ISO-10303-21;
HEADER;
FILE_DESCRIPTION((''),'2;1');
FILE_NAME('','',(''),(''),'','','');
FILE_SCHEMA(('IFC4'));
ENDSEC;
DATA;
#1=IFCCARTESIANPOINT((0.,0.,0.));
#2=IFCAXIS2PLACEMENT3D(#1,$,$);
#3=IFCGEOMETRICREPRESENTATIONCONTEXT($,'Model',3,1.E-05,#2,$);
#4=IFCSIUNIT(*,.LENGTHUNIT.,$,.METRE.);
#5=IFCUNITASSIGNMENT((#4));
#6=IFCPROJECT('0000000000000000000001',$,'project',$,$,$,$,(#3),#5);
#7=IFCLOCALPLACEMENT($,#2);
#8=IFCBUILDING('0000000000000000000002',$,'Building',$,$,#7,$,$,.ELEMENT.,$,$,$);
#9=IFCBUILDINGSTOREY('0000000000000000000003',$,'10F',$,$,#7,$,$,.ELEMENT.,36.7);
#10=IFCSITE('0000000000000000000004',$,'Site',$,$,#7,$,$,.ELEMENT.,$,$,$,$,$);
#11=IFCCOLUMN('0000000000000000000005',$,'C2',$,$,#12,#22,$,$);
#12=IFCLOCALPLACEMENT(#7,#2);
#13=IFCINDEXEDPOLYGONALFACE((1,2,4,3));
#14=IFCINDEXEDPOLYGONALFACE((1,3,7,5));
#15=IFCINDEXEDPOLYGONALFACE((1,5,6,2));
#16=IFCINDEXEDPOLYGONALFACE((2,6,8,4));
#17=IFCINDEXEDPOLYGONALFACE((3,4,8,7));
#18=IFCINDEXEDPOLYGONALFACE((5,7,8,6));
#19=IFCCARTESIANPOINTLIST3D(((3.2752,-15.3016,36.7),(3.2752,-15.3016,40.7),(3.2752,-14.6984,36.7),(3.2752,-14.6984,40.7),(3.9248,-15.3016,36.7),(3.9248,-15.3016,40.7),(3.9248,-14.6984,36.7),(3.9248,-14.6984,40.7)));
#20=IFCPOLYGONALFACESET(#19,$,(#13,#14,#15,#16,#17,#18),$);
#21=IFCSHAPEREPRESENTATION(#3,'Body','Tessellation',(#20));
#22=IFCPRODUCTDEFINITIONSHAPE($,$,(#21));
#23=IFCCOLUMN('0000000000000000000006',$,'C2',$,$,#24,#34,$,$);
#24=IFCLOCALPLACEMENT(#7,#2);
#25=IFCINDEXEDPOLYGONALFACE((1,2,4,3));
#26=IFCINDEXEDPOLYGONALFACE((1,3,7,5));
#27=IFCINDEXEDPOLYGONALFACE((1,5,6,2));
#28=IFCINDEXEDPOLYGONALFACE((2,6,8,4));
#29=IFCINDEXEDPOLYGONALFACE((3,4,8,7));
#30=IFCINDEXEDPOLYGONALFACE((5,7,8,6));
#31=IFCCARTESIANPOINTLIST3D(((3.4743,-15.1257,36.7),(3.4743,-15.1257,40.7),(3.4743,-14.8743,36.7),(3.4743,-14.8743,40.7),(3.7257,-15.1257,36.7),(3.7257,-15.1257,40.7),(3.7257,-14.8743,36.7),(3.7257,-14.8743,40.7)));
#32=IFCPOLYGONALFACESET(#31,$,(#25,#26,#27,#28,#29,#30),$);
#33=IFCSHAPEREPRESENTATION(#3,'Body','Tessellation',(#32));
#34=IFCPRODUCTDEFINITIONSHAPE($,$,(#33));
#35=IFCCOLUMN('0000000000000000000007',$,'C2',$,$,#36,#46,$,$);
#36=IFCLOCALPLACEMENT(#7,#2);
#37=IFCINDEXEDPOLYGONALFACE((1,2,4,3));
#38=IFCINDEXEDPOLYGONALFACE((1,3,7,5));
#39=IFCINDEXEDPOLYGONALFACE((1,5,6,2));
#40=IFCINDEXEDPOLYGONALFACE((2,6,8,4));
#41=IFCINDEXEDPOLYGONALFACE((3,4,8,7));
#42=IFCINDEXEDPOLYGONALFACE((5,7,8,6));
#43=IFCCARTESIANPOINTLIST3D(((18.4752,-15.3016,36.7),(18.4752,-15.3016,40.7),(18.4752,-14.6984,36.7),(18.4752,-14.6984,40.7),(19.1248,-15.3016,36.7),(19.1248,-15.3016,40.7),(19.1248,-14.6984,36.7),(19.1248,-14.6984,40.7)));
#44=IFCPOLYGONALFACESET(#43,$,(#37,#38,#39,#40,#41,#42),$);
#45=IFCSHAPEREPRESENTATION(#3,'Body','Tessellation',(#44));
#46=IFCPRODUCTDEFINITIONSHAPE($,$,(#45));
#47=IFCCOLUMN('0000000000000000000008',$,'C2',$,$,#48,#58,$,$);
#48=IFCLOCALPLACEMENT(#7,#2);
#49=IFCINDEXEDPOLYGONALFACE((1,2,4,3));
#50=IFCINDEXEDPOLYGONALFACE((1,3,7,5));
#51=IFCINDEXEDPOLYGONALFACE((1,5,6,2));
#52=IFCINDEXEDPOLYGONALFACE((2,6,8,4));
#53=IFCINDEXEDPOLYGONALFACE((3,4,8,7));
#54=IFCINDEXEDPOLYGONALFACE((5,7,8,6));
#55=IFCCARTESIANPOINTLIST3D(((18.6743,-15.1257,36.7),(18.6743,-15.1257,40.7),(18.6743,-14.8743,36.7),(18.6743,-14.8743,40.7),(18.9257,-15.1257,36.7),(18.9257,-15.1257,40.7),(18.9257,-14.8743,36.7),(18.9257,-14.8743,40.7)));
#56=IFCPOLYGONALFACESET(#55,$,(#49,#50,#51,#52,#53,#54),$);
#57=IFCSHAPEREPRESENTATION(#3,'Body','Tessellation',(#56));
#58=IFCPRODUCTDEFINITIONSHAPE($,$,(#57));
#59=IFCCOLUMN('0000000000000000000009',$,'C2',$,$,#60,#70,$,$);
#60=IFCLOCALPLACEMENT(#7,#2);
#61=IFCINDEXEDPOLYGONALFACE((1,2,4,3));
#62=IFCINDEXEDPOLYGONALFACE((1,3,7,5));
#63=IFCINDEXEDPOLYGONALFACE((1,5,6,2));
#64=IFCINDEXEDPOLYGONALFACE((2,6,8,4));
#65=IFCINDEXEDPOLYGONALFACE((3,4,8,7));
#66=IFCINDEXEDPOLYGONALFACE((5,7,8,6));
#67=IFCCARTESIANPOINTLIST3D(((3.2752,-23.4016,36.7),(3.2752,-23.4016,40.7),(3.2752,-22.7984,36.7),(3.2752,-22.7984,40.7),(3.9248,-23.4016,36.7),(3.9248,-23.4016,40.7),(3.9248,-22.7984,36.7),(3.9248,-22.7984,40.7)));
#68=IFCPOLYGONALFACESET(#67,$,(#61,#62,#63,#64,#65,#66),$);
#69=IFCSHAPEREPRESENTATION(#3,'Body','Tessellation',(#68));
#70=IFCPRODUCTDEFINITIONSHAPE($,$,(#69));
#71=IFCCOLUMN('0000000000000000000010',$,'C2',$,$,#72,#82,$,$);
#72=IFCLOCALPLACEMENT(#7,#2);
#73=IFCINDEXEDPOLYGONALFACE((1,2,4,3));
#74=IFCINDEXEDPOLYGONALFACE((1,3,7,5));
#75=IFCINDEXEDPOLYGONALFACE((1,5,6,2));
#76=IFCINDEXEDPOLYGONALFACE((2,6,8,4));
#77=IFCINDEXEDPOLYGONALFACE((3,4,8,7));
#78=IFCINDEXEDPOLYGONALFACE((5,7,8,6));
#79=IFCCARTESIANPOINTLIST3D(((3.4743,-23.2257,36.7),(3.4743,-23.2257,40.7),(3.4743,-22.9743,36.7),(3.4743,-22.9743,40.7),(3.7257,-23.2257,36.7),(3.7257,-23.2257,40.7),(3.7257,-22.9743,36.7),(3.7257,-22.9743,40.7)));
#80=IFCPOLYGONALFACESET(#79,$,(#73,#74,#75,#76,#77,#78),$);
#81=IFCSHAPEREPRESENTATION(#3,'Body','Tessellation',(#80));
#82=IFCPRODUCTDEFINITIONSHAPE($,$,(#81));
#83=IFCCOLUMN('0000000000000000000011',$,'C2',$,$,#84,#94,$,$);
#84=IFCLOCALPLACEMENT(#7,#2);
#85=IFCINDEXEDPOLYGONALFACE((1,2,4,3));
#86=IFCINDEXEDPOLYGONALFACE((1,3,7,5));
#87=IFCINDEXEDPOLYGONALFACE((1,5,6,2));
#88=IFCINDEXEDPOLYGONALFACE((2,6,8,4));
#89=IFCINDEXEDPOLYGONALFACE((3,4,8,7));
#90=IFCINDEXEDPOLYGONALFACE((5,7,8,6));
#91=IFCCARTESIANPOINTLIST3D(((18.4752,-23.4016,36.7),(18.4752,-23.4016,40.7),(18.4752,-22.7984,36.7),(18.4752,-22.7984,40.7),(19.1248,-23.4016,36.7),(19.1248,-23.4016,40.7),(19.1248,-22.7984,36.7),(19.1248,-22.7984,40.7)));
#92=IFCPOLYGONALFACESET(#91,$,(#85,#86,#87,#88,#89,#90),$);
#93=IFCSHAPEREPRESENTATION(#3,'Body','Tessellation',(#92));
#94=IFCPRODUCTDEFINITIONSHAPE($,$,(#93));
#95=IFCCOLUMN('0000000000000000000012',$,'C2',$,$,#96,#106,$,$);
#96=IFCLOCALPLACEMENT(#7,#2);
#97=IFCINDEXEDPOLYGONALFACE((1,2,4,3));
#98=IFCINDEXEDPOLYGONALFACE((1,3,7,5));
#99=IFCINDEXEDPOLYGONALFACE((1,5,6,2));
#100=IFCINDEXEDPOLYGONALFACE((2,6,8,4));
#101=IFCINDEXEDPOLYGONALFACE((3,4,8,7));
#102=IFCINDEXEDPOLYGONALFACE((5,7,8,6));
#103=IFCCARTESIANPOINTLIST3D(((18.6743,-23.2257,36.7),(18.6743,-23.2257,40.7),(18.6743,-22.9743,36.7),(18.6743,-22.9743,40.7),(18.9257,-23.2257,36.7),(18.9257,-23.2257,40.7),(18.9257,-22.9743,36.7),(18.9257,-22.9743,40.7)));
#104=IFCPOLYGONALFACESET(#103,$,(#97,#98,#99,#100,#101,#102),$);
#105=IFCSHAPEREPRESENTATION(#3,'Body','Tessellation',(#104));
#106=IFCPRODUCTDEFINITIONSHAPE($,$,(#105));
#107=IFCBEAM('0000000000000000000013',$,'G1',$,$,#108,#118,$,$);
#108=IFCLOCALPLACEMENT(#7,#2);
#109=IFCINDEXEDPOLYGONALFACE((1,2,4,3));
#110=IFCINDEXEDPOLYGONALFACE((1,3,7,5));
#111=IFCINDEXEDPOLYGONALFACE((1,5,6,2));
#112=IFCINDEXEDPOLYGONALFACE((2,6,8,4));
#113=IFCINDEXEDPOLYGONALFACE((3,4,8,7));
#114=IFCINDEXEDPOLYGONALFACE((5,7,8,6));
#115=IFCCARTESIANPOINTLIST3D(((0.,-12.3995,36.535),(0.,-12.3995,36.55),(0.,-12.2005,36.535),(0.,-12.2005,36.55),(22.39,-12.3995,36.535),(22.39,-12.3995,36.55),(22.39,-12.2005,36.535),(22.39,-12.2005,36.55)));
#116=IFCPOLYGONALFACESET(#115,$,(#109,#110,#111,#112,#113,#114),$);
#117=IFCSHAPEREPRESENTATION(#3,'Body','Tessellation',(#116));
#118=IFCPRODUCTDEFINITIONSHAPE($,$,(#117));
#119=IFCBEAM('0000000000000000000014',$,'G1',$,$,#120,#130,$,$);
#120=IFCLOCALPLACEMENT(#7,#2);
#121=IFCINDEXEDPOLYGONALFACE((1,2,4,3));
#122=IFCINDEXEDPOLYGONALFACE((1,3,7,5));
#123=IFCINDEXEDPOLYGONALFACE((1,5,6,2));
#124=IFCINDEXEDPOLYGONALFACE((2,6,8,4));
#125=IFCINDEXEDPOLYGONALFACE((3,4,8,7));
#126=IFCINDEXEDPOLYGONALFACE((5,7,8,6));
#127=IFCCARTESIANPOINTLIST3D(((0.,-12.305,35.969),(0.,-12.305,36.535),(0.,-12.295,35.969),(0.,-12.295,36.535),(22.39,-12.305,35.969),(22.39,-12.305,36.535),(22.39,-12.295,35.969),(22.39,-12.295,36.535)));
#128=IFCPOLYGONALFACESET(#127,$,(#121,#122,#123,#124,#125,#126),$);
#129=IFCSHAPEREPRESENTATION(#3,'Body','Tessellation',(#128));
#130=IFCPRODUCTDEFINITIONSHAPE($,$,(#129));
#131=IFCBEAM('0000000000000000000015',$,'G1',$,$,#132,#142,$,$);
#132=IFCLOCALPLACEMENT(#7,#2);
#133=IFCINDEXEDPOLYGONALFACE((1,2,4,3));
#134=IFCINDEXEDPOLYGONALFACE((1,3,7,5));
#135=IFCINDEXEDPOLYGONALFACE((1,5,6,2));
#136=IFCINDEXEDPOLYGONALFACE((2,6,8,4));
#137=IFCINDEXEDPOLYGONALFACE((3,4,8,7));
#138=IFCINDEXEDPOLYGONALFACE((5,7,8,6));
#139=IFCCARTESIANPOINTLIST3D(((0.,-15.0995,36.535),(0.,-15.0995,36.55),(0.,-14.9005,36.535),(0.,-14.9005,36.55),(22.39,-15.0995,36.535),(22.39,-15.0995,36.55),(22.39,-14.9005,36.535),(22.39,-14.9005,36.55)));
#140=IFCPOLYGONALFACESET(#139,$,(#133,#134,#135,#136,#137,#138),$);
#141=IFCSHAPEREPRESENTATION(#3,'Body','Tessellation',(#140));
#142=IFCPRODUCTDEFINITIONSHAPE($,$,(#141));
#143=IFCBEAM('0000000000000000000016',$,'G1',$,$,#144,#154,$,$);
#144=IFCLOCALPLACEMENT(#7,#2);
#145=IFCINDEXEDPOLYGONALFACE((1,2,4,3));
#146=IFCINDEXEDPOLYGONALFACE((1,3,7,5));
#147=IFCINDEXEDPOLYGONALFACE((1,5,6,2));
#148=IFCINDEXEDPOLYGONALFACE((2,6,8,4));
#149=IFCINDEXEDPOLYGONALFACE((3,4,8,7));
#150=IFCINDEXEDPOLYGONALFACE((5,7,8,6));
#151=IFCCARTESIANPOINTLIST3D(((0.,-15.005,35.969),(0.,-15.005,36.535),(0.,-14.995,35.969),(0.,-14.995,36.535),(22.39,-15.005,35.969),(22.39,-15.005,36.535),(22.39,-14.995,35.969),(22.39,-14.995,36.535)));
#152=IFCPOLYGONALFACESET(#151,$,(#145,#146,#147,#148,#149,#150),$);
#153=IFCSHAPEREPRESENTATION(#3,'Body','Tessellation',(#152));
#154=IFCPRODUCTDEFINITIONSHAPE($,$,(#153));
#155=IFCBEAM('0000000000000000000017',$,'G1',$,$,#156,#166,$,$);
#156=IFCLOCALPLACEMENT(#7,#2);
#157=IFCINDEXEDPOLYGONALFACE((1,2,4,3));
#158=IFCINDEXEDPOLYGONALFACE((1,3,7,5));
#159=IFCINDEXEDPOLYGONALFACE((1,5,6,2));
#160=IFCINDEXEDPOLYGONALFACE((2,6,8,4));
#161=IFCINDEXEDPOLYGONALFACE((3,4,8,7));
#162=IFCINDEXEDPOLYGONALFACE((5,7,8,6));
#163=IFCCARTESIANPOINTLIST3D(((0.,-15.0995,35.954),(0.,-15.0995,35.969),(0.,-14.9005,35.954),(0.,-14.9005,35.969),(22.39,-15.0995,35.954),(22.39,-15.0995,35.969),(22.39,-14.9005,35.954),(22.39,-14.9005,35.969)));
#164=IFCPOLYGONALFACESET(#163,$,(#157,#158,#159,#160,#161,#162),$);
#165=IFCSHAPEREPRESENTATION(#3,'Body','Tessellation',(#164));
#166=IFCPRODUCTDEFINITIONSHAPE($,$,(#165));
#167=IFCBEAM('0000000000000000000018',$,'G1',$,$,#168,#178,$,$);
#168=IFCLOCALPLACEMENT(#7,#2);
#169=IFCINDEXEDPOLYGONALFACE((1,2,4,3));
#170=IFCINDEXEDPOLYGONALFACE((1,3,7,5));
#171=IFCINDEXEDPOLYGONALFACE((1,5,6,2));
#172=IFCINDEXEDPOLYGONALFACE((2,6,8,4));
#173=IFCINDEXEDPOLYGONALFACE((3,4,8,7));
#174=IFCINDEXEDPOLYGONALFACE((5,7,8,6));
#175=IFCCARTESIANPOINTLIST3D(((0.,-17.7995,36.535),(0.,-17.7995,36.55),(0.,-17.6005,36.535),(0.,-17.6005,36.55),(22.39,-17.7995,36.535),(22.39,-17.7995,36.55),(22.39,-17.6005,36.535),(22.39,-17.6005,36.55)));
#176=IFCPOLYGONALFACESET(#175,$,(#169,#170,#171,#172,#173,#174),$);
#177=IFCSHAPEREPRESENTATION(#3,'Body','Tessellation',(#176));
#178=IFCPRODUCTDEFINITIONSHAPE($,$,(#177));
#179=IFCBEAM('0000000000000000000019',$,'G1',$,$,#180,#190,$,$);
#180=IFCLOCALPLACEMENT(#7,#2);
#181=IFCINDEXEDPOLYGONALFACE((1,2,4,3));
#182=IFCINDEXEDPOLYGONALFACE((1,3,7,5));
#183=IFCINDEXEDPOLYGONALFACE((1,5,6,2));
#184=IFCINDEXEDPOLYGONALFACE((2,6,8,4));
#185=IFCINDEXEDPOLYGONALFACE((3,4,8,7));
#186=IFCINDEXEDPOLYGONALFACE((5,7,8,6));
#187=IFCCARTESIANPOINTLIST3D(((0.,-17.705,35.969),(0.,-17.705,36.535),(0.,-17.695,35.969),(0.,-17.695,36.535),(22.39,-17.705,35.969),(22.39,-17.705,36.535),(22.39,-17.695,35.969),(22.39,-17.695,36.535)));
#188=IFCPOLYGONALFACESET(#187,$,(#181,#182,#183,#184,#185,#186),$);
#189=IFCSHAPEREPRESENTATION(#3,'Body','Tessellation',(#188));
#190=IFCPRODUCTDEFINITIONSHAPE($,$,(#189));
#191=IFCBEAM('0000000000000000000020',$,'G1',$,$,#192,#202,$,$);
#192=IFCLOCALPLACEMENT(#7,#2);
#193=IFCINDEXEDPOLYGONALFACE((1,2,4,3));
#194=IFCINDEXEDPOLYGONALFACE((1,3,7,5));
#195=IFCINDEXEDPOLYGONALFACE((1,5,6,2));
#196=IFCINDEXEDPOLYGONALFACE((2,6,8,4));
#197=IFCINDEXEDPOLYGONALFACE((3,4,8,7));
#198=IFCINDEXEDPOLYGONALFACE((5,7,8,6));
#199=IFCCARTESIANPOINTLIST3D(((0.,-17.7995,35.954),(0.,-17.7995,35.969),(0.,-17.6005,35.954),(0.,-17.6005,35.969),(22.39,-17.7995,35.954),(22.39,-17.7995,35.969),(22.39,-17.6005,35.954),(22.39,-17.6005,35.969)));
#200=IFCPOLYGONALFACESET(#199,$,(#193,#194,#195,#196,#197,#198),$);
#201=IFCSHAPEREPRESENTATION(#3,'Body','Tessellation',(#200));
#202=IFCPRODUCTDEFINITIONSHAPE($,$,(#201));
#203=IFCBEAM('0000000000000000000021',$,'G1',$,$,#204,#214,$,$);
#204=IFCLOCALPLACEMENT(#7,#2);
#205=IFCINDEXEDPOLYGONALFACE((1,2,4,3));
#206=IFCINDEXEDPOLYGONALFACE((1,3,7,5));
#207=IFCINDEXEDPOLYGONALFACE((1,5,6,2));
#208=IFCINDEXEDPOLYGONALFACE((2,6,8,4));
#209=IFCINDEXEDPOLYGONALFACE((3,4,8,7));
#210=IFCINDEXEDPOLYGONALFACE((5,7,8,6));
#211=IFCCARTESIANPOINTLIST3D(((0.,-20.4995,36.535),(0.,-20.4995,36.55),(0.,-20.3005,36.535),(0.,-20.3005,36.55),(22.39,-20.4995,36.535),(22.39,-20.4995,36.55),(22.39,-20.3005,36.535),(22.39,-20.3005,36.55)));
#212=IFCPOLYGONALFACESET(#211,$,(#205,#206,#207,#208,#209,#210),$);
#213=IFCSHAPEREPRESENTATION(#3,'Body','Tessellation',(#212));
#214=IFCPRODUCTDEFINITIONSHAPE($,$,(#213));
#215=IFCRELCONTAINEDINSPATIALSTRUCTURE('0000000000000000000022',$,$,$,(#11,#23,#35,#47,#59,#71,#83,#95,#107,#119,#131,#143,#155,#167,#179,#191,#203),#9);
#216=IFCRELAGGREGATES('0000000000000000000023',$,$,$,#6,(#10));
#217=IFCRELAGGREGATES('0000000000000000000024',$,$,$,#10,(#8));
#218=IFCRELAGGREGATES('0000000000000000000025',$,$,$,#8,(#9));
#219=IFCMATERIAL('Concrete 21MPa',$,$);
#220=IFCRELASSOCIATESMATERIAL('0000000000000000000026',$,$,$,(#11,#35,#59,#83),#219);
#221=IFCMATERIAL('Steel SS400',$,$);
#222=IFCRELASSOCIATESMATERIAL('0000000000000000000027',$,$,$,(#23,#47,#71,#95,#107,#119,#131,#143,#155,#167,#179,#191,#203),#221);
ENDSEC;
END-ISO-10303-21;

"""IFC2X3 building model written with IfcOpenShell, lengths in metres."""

from ifc_helpers import new_model, si_unit, frame, origin, origin_2d, place, context, project, spatial, rectangle, extrude, material, element, save


model = new_model("IFC2X3")

# Units and contexts
model_context = context("Model", 3, precision=1e-05, world=origin())
ifc_project = project(units=[si_unit("LENGTHUNIT", "METRE")], contexts=[model_context])

# Site, building, storey
placement = place(None, origin())
site = spatial("IfcSite", under=ifc_project, at=placement, Name="Site", CompositionType="ELEMENT")
building = spatial("IfcBuilding", under=site, at=placement, Name="Building", CompositionType="ELEMENT")
storey = spatial("IfcBuildingStorey", under=building, at=placement, Name="10F", CompositionType="ELEMENT", Elevation=36.7)

# Columns
ifc_material_1 = material(Name="Concrete 21MPa")
column_1_placement = place(None, frame((3.6, -15.0, 36.7)))
element("IfcColumn", 1, at=column_1_placement, inside=storey, material=ifc_material_1, Name="C2", context=model_context, shape_type="SweptSolid", body=[
    extrude(rectangle(XDim=0.6496, YDim=0.6032, at=origin_2d()), origin(), (0.0, 0.0, 1.0), 4.0),
])
ifc_material_2 = material(Name="Steel SS400")
column_2_placement = place(None, frame((3.6, -15.0, 36.7)))
element("IfcColumn", 2, at=column_2_placement, inside=storey, material=ifc_material_2, Name="C2", context=model_context, shape_type="SweptSolid", body=[
    extrude(rectangle(XDim=0.2513, YDim=0.2513, at=origin_2d()), origin(), (0.0, 0.0, 1.0), 4.0),
])
column_3_placement = place(None, frame((18.8, -15.0, 36.7)))
element("IfcColumn", 3, at=column_3_placement, inside=storey, material=ifc_material_1, Name="C2", context=model_context, shape_type="SweptSolid", body=[
    extrude(rectangle(XDim=0.6496, YDim=0.6032, at=origin_2d()), origin(), (0.0, 0.0, 1.0), 4.0),
])
column_4_placement = place(None, frame((18.8, -15.0, 36.7)))
element("IfcColumn", 4, at=column_4_placement, inside=storey, material=ifc_material_2, Name="C2", context=model_context, shape_type="SweptSolid", body=[
    extrude(rectangle(XDim=0.2513, YDim=0.2513, at=origin_2d()), origin(), (0.0, 0.0, 1.0), 4.0),
])
column_5_placement = place(None, frame((3.6, -23.1, 36.7)))
element("IfcColumn", 5, at=column_5_placement, inside=storey, material=ifc_material_1, Name="C2", context=model_context, shape_type="SweptSolid", body=[
    extrude(rectangle(XDim=0.6496, YDim=0.6032, at=origin_2d()), origin(), (0.0, 0.0, 1.0), 4.0),
])
column_6_placement = place(None, frame((3.6, -23.1, 36.7)))
element("IfcColumn", 6, at=column_6_placement, inside=storey, material=ifc_material_2, Name="C2", context=model_context, shape_type="SweptSolid", body=[
    extrude(rectangle(XDim=0.2513, YDim=0.2513, at=origin_2d()), origin(), (0.0, 0.0, 1.0), 4.0),
])
column_7_placement = place(None, frame((18.8, -23.1, 36.7)))
element("IfcColumn", 7, at=column_7_placement, inside=storey, material=ifc_material_1, Name="C2", context=model_context, shape_type="SweptSolid", body=[
    extrude(rectangle(XDim=0.6496, YDim=0.6032, at=origin_2d()), origin(), (0.0, 0.0, 1.0), 4.0),
])
column_8_placement = place(None, frame((18.8, -23.1, 36.7)))
element("IfcColumn", 8, at=column_8_placement, inside=storey, material=ifc_material_2, Name="C2", context=model_context, shape_type="SweptSolid", body=[
    extrude(rectangle(XDim=0.2513, YDim=0.2513, at=origin_2d()), origin(), (0.0, 0.0, 1.0), 4.0),
])

# Beams
beam_1_placement = place(None, frame((11.195, -12.3, 36.535)))
element("IfcBeam", 9, at=beam_1_placement, inside=storey, material=ifc_material_2, Name="G1", context=model_context, shape_type="SweptSolid", body=[
    extrude(rectangle(XDim=22.39, YDim=0.199, at=origin_2d()), origin(), (0.0, 0.0, 1.0), 0.015),
])
beam_2_placement = place(None, frame((11.195, -12.3, 35.969)))
element("IfcBeam", 10, at=beam_2_placement, inside=storey, material=ifc_material_2, Name="G1", context=model_context, shape_type="SweptSolid", body=[
    extrude(rectangle(XDim=22.39, YDim=0.01, at=origin_2d()), origin(), (0.0, 0.0, 1.0), 0.566),
])
beam_3_placement = place(None, frame((11.195, -15.0, 36.535)))
element("IfcBeam", 11, at=beam_3_placement, inside=storey, material=ifc_material_2, Name="G1", context=model_context, shape_type="SweptSolid", body=[
    extrude(rectangle(XDim=22.39, YDim=0.199, at=origin_2d()), origin(), (0.0, 0.0, 1.0), 0.015),
])
beam_4_placement = place(None, frame((11.195, -15.0, 35.969)))
element("IfcBeam", 12, at=beam_4_placement, inside=storey, material=ifc_material_2, Name="G1", context=model_context, shape_type="SweptSolid", body=[
    extrude(rectangle(XDim=22.39, YDim=0.01, at=origin_2d()), origin(), (0.0, 0.0, 1.0), 0.566),
])
for number, where, name in (
    (13, (11.195, -15.0, 35.954), "G1"),
    (14, (11.195, -17.7, 36.535), "G1"),
):
    element("IfcBeam", number, at=place(None, frame(where)), inside=storey, material=ifc_material_2, Name=name, context=model_context, shape_type="SweptSolid", body=[
        extrude(rectangle(XDim=22.39, YDim=0.199, at=origin_2d()), origin(), (0.0, 0.0, 1.0), 0.015),
    ])
beam_5_placement = place(None, frame((11.195, -17.7, 35.969)))
element("IfcBeam", 15, at=beam_5_placement, inside=storey, material=ifc_material_2, Name="G1", context=model_context, shape_type="SweptSolid", body=[
    extrude(rectangle(XDim=22.39, YDim=0.01, at=origin_2d()), origin(), (0.0, 0.0, 1.0), 0.566),
])
for number, where, name in (
    (16, (11.195, -17.7, 35.954), "G1"),
    (17, (11.195, -20.4, 36.535), "G1"),
):
    element("IfcBeam", number, at=place(None, frame(where)), inside=storey, material=ifc_material_2, Name=name, context=model_context, shape_type="SweptSolid", body=[
        extrude(rectangle(XDim=22.39, YDim=0.199, at=origin_2d()), origin(), (0.0, 0.0, 1.0), 0.015),
    ])

save(model, "model.ifc")
